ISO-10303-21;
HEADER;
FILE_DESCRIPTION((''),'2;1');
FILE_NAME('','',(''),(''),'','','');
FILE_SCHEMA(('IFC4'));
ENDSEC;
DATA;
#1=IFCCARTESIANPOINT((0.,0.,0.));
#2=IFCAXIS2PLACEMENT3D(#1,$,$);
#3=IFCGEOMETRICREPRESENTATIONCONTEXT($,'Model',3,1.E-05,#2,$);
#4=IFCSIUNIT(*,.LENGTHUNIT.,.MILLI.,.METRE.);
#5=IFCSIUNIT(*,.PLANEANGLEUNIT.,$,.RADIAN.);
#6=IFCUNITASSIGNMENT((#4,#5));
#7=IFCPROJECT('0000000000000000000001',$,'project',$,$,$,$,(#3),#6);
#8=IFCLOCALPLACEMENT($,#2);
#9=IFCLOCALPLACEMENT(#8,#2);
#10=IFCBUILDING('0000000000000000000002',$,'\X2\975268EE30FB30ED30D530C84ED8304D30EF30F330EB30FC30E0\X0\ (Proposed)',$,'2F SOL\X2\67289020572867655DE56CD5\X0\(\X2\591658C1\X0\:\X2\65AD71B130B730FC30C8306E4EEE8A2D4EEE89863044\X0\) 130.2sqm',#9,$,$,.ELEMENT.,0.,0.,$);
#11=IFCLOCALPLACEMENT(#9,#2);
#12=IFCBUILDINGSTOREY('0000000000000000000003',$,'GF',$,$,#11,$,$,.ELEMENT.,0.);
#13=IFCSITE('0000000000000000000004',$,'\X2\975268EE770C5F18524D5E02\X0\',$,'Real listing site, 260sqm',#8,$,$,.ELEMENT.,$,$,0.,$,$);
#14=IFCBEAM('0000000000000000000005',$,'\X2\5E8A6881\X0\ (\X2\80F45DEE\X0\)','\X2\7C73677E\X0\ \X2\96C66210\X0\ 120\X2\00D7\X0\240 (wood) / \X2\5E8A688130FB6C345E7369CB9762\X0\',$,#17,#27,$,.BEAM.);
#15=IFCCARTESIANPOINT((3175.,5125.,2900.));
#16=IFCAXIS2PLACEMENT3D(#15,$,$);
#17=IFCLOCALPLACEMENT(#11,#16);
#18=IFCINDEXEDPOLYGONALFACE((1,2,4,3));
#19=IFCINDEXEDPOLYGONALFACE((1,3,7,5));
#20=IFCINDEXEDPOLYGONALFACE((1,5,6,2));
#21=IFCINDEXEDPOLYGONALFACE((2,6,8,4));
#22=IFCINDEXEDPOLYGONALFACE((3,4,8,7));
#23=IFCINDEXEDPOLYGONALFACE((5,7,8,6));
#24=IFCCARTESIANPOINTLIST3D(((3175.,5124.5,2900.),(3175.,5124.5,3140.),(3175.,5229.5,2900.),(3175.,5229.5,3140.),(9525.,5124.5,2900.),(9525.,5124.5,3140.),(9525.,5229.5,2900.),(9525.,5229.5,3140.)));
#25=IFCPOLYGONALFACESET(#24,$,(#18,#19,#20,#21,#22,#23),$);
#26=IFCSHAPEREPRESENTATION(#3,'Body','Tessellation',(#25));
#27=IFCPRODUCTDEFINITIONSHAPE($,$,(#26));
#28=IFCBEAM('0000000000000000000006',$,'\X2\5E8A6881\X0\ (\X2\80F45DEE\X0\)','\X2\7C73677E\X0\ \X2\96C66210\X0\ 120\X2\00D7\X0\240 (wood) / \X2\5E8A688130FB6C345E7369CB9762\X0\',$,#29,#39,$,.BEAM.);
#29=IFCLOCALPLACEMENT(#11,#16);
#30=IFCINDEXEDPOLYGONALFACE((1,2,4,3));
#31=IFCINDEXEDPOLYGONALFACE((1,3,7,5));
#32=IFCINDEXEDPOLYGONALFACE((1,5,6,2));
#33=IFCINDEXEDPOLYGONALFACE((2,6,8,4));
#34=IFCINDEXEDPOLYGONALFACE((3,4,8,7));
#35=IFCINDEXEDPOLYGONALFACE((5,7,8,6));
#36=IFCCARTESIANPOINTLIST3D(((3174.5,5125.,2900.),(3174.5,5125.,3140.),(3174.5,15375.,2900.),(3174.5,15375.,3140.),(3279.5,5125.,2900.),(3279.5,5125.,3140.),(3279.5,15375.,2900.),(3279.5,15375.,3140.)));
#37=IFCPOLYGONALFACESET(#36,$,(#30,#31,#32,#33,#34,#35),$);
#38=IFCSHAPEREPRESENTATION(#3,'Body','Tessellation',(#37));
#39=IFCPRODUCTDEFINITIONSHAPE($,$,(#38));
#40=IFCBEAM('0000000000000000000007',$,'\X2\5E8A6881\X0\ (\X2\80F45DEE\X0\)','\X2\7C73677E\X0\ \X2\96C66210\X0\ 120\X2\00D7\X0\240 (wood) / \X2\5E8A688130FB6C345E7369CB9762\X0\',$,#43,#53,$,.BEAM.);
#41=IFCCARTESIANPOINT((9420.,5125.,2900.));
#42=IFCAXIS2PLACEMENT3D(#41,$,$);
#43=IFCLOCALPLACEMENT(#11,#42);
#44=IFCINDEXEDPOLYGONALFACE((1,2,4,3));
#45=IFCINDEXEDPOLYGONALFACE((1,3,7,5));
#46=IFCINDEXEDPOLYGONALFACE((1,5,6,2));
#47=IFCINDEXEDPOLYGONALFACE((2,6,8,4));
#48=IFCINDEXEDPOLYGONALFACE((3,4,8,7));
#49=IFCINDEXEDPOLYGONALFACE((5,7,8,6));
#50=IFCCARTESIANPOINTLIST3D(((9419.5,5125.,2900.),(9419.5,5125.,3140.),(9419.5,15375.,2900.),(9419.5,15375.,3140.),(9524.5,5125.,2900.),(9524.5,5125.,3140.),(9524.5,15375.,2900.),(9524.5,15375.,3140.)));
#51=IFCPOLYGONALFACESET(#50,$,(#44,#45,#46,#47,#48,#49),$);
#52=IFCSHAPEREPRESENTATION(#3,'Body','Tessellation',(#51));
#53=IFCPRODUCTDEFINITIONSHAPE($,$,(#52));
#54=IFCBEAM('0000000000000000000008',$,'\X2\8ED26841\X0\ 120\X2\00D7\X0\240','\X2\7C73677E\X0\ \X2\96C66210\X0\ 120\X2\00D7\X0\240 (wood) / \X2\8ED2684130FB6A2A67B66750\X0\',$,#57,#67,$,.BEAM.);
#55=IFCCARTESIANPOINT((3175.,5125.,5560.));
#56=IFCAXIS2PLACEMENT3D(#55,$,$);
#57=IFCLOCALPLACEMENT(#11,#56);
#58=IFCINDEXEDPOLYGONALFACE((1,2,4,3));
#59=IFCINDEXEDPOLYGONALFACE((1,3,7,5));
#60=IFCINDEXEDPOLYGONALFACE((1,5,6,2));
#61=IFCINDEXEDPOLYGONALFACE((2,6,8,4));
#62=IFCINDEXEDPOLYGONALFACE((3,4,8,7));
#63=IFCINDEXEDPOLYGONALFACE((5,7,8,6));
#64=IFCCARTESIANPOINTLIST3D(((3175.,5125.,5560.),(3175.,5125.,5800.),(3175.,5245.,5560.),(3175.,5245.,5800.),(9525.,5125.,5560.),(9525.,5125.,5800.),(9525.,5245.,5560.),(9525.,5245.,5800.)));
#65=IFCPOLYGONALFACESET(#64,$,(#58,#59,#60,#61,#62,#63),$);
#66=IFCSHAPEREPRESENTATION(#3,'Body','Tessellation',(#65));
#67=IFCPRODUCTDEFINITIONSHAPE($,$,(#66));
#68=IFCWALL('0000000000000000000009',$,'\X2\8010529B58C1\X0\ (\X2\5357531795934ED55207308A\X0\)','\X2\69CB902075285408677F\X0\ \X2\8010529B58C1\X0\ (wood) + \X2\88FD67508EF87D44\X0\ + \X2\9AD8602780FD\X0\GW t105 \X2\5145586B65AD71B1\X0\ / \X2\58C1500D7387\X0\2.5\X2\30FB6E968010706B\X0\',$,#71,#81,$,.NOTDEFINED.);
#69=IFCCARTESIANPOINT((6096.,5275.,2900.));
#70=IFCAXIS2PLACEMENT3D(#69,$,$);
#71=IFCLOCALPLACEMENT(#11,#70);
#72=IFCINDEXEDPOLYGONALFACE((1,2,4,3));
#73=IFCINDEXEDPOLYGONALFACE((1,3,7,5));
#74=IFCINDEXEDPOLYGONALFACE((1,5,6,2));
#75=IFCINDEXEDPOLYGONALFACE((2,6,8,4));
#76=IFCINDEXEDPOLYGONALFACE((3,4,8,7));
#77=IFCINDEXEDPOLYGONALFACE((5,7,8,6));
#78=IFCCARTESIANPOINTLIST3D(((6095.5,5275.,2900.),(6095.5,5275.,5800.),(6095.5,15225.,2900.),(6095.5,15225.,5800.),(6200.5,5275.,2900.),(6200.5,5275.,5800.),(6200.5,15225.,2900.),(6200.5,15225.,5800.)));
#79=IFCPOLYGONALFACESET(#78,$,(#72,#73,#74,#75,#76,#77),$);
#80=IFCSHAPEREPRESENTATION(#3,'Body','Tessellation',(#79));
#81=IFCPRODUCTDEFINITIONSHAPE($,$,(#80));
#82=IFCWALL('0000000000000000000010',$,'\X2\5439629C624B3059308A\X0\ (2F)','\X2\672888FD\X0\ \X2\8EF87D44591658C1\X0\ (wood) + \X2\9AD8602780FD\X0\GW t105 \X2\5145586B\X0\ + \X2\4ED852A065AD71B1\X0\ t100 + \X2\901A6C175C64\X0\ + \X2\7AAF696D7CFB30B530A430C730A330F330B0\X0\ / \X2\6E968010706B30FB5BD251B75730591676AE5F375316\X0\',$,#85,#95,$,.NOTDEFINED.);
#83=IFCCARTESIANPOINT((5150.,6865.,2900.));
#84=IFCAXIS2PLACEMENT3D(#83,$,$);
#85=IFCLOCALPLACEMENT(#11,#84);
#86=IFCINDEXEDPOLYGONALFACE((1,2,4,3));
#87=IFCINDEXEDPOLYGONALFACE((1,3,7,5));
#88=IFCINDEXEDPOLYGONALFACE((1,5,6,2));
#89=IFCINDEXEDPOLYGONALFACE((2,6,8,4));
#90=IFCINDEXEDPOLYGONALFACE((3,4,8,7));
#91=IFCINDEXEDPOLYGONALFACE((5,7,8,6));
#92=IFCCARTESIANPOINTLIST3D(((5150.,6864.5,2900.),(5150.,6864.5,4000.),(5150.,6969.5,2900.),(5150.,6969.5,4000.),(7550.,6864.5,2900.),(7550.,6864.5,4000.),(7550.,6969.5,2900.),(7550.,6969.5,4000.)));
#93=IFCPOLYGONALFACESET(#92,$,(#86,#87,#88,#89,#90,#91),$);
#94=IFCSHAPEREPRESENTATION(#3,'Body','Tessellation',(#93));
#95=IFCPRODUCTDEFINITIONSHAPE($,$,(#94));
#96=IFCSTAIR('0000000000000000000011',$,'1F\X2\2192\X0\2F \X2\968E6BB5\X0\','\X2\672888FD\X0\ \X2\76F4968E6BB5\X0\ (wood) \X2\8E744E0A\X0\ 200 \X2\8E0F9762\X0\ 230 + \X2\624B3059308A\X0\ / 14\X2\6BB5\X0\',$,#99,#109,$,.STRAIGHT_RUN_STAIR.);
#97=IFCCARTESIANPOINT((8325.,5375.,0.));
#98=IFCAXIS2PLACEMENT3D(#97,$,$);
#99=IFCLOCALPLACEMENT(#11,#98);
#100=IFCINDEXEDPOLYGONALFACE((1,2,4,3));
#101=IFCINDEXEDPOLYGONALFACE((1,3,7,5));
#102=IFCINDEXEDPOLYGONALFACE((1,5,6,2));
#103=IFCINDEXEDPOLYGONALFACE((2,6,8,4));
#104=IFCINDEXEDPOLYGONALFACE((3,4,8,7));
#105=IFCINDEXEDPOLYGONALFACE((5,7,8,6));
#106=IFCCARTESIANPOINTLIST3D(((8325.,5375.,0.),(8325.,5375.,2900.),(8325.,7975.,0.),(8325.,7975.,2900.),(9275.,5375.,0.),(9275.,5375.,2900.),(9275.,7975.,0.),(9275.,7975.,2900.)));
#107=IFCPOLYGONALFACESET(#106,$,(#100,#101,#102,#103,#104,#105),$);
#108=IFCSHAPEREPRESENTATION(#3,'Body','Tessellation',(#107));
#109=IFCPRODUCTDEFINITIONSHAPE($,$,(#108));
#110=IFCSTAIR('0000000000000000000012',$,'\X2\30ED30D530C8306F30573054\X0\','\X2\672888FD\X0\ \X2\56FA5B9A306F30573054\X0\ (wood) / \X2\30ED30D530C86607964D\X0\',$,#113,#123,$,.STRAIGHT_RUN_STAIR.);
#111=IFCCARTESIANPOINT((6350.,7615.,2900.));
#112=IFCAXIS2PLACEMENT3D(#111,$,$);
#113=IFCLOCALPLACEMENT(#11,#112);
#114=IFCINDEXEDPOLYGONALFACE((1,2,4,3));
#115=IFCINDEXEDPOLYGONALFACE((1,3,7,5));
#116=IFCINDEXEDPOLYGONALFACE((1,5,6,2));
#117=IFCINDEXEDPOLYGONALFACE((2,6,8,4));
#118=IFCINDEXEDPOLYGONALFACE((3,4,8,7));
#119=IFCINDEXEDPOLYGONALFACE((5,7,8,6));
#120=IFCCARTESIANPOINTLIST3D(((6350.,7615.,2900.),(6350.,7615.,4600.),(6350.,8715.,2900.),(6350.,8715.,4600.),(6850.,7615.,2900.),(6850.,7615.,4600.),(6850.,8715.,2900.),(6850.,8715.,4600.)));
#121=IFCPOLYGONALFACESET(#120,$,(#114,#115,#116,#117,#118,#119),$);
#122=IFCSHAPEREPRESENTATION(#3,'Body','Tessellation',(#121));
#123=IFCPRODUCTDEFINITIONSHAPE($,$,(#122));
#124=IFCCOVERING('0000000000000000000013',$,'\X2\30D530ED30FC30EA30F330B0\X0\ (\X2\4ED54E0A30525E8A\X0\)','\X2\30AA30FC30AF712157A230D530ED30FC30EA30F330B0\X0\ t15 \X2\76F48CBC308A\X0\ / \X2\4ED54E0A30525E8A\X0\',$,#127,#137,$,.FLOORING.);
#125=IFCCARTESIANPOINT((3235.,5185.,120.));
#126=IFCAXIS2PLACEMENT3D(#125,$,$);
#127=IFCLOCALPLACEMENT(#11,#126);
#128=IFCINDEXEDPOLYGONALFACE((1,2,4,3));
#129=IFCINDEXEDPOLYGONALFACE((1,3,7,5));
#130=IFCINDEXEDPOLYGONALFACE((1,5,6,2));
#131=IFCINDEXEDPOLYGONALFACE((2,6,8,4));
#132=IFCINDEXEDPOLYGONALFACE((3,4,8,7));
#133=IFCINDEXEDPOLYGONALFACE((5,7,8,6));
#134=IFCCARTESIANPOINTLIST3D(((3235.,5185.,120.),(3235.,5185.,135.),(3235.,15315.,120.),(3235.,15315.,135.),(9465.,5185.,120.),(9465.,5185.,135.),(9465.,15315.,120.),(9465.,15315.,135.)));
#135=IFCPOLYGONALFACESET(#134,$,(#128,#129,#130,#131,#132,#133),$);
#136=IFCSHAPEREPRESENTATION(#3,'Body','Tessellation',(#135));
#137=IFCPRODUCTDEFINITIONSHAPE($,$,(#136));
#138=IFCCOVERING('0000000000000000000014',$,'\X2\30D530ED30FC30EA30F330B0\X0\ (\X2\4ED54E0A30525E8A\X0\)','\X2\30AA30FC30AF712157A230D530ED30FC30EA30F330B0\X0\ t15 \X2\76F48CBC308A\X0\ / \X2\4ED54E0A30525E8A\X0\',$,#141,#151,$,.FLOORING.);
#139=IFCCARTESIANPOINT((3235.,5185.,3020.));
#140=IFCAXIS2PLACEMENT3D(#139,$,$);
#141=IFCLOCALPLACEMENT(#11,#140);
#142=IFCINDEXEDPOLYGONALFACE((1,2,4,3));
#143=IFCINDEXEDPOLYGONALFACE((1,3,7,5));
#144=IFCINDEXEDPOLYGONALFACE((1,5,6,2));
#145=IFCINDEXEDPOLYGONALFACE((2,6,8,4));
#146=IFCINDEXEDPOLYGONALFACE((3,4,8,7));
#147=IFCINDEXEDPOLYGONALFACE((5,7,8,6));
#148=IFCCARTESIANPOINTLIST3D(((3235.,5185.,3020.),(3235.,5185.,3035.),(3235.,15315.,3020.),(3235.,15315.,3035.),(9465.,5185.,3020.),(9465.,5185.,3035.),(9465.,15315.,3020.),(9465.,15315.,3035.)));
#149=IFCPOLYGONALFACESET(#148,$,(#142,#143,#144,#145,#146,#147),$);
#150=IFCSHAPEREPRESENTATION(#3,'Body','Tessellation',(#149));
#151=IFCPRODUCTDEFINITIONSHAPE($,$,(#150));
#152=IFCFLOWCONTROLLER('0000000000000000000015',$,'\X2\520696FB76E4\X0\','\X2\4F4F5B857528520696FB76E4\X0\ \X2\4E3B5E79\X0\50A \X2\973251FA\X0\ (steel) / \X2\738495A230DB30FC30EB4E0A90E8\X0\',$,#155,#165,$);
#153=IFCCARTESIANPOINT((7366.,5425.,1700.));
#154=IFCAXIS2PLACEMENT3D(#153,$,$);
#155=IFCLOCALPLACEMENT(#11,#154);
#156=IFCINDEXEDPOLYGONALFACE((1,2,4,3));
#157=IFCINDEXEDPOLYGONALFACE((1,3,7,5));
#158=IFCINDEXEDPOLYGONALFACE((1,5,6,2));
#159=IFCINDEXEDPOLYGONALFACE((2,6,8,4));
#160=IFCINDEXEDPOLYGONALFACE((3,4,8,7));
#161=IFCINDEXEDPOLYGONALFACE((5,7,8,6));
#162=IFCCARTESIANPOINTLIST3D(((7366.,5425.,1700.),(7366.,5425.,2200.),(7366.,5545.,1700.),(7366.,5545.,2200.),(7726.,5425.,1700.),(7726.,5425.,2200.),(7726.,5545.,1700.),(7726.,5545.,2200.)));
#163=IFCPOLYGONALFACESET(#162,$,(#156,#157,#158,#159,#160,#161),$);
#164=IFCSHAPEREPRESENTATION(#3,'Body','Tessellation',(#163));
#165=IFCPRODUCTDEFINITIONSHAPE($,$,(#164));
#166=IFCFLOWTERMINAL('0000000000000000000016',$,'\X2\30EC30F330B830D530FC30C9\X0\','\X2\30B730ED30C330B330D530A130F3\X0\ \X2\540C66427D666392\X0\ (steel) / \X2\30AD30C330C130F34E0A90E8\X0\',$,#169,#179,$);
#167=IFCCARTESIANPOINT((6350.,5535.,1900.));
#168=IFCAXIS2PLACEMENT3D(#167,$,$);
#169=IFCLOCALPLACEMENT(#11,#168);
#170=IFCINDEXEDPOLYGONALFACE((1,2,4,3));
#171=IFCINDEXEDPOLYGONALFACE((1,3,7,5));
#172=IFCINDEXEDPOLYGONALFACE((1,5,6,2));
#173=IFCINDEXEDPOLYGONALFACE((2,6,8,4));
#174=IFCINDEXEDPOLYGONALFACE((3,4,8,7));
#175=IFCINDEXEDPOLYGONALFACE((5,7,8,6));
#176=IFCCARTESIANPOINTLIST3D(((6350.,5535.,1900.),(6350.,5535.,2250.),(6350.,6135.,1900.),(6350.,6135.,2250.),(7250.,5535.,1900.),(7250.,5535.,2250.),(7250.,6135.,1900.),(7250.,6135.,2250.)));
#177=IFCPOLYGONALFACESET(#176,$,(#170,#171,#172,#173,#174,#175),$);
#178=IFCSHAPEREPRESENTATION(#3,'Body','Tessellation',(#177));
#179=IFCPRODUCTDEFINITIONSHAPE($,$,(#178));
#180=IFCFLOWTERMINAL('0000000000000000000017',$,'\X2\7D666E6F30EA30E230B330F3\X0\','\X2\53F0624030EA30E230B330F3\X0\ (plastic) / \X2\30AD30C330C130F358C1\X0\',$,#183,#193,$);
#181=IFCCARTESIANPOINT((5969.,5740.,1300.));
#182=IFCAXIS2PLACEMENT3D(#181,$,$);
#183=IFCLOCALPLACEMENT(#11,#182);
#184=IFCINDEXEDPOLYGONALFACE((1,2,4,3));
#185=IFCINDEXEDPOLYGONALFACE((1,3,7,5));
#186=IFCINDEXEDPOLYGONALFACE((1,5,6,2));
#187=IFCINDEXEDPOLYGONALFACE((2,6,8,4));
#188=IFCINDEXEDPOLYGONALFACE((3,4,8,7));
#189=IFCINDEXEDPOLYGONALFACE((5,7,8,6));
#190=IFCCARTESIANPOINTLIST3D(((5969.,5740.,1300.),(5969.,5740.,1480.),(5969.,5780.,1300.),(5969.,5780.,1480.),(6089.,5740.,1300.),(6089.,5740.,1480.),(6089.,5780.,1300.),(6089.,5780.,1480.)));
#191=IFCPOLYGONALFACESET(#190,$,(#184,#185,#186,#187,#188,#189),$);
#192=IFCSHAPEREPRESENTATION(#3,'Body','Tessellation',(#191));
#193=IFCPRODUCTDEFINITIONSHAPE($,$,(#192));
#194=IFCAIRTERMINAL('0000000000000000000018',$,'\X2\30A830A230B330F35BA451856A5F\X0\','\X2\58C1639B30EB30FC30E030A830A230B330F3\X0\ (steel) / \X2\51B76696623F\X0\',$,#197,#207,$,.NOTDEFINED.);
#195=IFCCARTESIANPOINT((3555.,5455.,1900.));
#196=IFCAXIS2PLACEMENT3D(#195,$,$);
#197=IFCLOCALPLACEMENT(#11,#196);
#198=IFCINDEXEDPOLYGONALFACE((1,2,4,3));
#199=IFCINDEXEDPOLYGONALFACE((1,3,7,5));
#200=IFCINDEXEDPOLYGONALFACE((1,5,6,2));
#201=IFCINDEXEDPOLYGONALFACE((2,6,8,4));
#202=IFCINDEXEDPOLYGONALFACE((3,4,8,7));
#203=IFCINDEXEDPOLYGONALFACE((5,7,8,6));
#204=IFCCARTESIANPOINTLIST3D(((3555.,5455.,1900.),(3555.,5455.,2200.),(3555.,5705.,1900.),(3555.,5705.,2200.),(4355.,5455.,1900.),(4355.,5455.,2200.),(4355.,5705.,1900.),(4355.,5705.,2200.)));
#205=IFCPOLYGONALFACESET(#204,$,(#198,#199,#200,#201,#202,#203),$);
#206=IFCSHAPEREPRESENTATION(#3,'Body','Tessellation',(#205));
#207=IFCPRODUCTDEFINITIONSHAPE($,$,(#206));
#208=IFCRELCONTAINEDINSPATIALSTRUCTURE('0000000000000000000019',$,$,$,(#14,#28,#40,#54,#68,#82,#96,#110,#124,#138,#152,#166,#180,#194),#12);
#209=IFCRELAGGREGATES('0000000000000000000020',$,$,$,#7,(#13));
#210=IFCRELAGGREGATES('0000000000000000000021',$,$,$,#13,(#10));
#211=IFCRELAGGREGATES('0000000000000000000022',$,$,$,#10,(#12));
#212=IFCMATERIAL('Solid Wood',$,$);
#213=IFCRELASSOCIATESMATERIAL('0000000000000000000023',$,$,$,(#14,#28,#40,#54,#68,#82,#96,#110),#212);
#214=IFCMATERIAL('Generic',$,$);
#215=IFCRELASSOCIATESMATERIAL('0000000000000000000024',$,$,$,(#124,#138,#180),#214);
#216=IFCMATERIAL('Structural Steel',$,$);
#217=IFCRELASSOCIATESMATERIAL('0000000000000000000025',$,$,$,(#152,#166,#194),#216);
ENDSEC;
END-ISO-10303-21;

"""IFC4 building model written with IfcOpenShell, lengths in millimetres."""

from ifc_helpers import new_model, si_unit, frame, frame_2d, origin, place, context, project, spatial, rectangle, extrude, material, element, save


model = new_model("IFC4")

# Units and contexts
model_context = context("Model", 3, precision=1e-05, world=origin())
ifc_project = project(units=[si_unit("LENGTHUNIT", "METRE", prefix="MILLI"), si_unit("PLANEANGLEUNIT", "RADIAN")], contexts=[model_context])

# Site, building, storey
site_placement = place(None, origin())
site = spatial("IfcSite", under=ifc_project, at=site_placement, Name="青森県弘前市", ObjectType="Real listing site, 260sqm", CompositionType="ELEMENT", RefElevation=0.0)
building_placement = place(site_placement, origin())
building = spatial("IfcBuilding", under=site, at=building_placement, Name="青森・ロフト付きワンルーム (Proposed)", ObjectType="2F SOL木造在来工法(外壁:断熱シートの仮設仮覆い) 130.2sqm", CompositionType="ELEMENT", ElevationOfRefHeight=0.0, ElevationOfTerrain=0.0)
storey_placement = place(building_placement, origin())
storey = spatial("IfcBuildingStorey", under=building, at=storey_placement, Name="GF", CompositionType="ELEMENT", Elevation=0.0)

# Shared definitions
ifc_material_1 = material(Name="Solid Wood")

# Beams
beam_1_placement = place(storey_placement, frame((3175.0, 5125.0, 2900.0)))
element("IfcBeam", 1, at=beam_1_placement, inside=storey, material=ifc_material_1, Name="床梁 (胴差)", Description="米松 集成 120×240 (wood) / 床梁・水平構面", PredefinedType="BEAM", context=model_context, shape_type="SweptSolid", body=[
    extrude(rectangle(XDim=6350.0, YDim=105.0, at=frame_2d((3175.0, 52.0))), frame((3175.0, 5125.0, 2900.0)), (0.0, 0.0, 1.0), 240.0),
])
beam_2_placement = place(storey_placement, frame((3175.0, 5125.0, 2900.0)))
element("IfcBeam", 2, at=beam_2_placement, inside=storey, material=ifc_material_1, Name="床梁 (胴差)", Description="米松 集成 120×240 (wood) / 床梁・水平構面", PredefinedType="BEAM", context=model_context, shape_type="SweptSolid", body=[
    extrude(rectangle(XDim=105.0, YDim=10250.0, at=frame_2d((52.0, 5125.0))), frame((3175.0, 5125.0, 2900.0)), (0.0, 0.0, 1.0), 240.0),
])
beam_3_placement = place(storey_placement, frame((9420.0, 5125.0, 2900.0)))
element("IfcBeam", 3, at=beam_3_placement, inside=storey, material=ifc_material_1, Name="床梁 (胴差)", Description="米松 集成 120×240 (wood) / 床梁・水平構面", PredefinedType="BEAM", context=model_context, shape_type="SweptSolid", body=[
    extrude(rectangle(XDim=105.0, YDim=10250.0, at=frame_2d((52.0, 5125.0))), frame((9420.0, 5125.0, 2900.0)), (0.0, 0.0, 1.0), 240.0),
])
beam_4_placement = place(storey_placement, frame((3175.0, 5125.0, 5560.0)))
element("IfcBeam", 4, at=beam_4_placement, inside=storey, material=ifc_material_1, Name="軒桁 120×240", Description="米松 集成 120×240 (wood) / 軒桁・横架材", PredefinedType="BEAM", context=model_context, shape_type="SweptSolid", body=[
    extrude(rectangle(XDim=6350.0, YDim=120.0, at=frame_2d((3175.0, 60.0))), frame((3175.0, 5125.0, 5560.0)), (0.0, 0.0, 1.0), 240.0),
])

# Walls
wall_1_placement = place(storey_placement, frame((6096.0, 5275.0, 2900.0)))
element("IfcWall", 5, at=wall_1_placement, inside=storey, material=ifc_material_1, Name="耐力壁 (南北間仕切り)", Description="構造用合板 耐力壁 (wood) + 製材軸組 + 高性能GW t105 充填断熱 / 壁倍率2.5・準耐火", PredefinedType="NOTDEFINED", context=model_context, shape_type="SweptSolid", body=[
    extrude(rectangle(XDim=105.0, YDim=9950.0, at=frame_2d((52.0, 4975.0))), frame((6096.0, 5275.0, 2900.0)), (0.0, 0.0, 1.0), 2900.0),
])
wall_2_placement = place(storey_placement, frame((5150.0, 6865.0, 2900.0)))
element("IfcWall", 6, at=wall_2_placement, inside=storey, material=ifc_material_1, Name="吹抜手すり (2F)", Description="木製 軸組外壁 (wood) + 高性能GW t105 充填 + 付加断熱 t100 + 通気層 + 窯業系サイディング / 準耐火・寒冷地外皮強化", PredefinedType="NOTDEFINED", context=model_context, shape_type="SweptSolid", body=[
    extrude(rectangle(XDim=2400.0, YDim=105.0, at=frame_2d((1200.0, 52.0))), frame((5150.0, 6865.0, 2900.0)), (0.0, 0.0, 1.0), 1100.0),
])

# Stairs
stair_1_placement = place(storey_placement, frame((8325.0, 5375.0, 0.0)))
element("IfcStair", 7, at=stair_1_placement, inside=storey, material=ifc_material_1, Name="1F→2F 階段", Description="木製 直階段 (wood) 蹴上 200 踏面 230 + 手すり / 14段", PredefinedType="STRAIGHT_RUN_STAIR", context=model_context, shape_type="SweptSolid", body=[
    extrude(rectangle(XDim=950.0, YDim=2600.0, at=frame_2d((475.0, 1300.0))), frame((8325.0, 5375.0, 0.0)), (0.0, 0.0, 1.0), 2900.0),
])
stair_2_placement = place(storey_placement, frame((6350.0, 7615.0, 2900.0)))
element("IfcStair", 8, at=stair_2_placement, inside=storey, material=ifc_material_1, Name="ロフトはしご", Description="木製 固定はしご (wood) / ロフト昇降", PredefinedType="STRAIGHT_RUN_STAIR", context=model_context, shape_type="SweptSolid", body=[
    extrude(rectangle(XDim=500.0, YDim=1100.0, at=frame_2d((250.0, 550.0))), frame((6350.0, 7615.0, 2900.0)), (0.0, 0.0, 1.0), 1700.0),
])

# Coverings
ifc_material_2 = material(Name="Generic")
covering_1_placement = place(storey_placement, frame((3235.0, 5185.0, 120.0)))
element("IfcCovering", 9, at=covering_1_placement, inside=storey, material=ifc_material_2, Name="フローリング (仕上げ床)", Description="オーク無垢フローリング t15 直貼り / 仕上げ床", PredefinedType="FLOORING", context=model_context, shape_type="SweptSolid", body=[
    extrude(rectangle(XDim=6230.0, YDim=10130.0, at=frame_2d((3115.0, 5065.0))), frame((3235.0, 5185.0, 120.0)), (0.0, 0.0, 1.0), 15.0),
])
covering_2_placement = place(storey_placement, frame((3235.0, 5185.0, 3020.0)))
element("IfcCovering", 10, at=covering_2_placement, inside=storey, material=ifc_material_2, Name="フローリング (仕上げ床)", Description="オーク無垢フローリング t15 直貼り / 仕上げ床", PredefinedType="FLOORING", context=model_context, shape_type="SweptSolid", body=[
    extrude(rectangle(XDim=6230.0, YDim=10130.0, at=frame_2d((3115.0, 5065.0))), frame((3235.0, 5185.0, 3020.0)), (0.0, 0.0, 1.0), 15.0),
])

# Flow controller
ifc_material_3 = material(Name="Structural Steel")
flow_controller_placement = place(storey_placement, frame((7366.0, 5425.0, 1700.0)))
element("IfcFlowController", 11, at=flow_controller_placement, inside=storey, material=ifc_material_3, Name="分電盤", Description="住宅用分電盤 主幹50A 露出 (steel) / 玄関ホール上部", context=model_context, shape_type="SweptSolid", body=[
    extrude(rectangle(XDim=360.0, YDim=120.0, at=frame_2d((180.0, 60.0))), frame((7366.0, 5425.0, 1700.0)), (0.0, 0.0, 1.0), 500.0),
])

# Flow terminals
flow_terminal_1_placement = place(storey_placement, frame((6350.0, 5535.0, 1900.0)))
element("IfcFlowTerminal", 12, at=flow_terminal_1_placement, inside=storey, material=ifc_material_3, Name="レンジフード", Description="シロッコファン 同時給排 (steel) / キッチン上部", context=model_context, shape_type="SweptSolid", body=[
    extrude(rectangle(XDim=900.0, YDim=600.0, at=frame_2d((450.0, 300.0))), frame((6350.0, 5535.0, 1900.0)), (0.0, 0.0, 1.0), 350.0),
])
flow_terminal_2_placement = place(storey_placement, frame((5969.0, 5740.0, 1300.0)))
element("IfcFlowTerminal", 13, at=flow_terminal_2_placement, inside=storey, material=ifc_material_2, Name="給湯リモコン", Description="台所リモコン (plastic) / キッチン壁", context=model_context, shape_type="SweptSolid", body=[
    extrude(rectangle(XDim=120.0, YDim=40.0, at=frame_2d((60.0, 20.0))), frame((5969.0, 5740.0, 1300.0)), (0.0, 0.0, 1.0), 180.0),
])

# Air terminal
air_terminal_1_placement = place(storey_placement, frame((3555.0, 5455.0, 1900.0)))
element("IfcAirTerminal", 14, at=air_terminal_1_placement, inside=storey, material=ifc_material_3, Name="エアコン室内機", Description="壁掛ルームエアコン (steel) / 冷暖房", PredefinedType="NOTDEFINED", context=model_context, shape_type="SweptSolid", body=[
    extrude(rectangle(XDim=800.0, YDim=250.0, at=frame_2d((400.0, 125.0))), frame((3555.0, 5455.0, 1900.0)), (0.0, 0.0, 1.0), 300.0),
])

save(model, "model.ifc")
